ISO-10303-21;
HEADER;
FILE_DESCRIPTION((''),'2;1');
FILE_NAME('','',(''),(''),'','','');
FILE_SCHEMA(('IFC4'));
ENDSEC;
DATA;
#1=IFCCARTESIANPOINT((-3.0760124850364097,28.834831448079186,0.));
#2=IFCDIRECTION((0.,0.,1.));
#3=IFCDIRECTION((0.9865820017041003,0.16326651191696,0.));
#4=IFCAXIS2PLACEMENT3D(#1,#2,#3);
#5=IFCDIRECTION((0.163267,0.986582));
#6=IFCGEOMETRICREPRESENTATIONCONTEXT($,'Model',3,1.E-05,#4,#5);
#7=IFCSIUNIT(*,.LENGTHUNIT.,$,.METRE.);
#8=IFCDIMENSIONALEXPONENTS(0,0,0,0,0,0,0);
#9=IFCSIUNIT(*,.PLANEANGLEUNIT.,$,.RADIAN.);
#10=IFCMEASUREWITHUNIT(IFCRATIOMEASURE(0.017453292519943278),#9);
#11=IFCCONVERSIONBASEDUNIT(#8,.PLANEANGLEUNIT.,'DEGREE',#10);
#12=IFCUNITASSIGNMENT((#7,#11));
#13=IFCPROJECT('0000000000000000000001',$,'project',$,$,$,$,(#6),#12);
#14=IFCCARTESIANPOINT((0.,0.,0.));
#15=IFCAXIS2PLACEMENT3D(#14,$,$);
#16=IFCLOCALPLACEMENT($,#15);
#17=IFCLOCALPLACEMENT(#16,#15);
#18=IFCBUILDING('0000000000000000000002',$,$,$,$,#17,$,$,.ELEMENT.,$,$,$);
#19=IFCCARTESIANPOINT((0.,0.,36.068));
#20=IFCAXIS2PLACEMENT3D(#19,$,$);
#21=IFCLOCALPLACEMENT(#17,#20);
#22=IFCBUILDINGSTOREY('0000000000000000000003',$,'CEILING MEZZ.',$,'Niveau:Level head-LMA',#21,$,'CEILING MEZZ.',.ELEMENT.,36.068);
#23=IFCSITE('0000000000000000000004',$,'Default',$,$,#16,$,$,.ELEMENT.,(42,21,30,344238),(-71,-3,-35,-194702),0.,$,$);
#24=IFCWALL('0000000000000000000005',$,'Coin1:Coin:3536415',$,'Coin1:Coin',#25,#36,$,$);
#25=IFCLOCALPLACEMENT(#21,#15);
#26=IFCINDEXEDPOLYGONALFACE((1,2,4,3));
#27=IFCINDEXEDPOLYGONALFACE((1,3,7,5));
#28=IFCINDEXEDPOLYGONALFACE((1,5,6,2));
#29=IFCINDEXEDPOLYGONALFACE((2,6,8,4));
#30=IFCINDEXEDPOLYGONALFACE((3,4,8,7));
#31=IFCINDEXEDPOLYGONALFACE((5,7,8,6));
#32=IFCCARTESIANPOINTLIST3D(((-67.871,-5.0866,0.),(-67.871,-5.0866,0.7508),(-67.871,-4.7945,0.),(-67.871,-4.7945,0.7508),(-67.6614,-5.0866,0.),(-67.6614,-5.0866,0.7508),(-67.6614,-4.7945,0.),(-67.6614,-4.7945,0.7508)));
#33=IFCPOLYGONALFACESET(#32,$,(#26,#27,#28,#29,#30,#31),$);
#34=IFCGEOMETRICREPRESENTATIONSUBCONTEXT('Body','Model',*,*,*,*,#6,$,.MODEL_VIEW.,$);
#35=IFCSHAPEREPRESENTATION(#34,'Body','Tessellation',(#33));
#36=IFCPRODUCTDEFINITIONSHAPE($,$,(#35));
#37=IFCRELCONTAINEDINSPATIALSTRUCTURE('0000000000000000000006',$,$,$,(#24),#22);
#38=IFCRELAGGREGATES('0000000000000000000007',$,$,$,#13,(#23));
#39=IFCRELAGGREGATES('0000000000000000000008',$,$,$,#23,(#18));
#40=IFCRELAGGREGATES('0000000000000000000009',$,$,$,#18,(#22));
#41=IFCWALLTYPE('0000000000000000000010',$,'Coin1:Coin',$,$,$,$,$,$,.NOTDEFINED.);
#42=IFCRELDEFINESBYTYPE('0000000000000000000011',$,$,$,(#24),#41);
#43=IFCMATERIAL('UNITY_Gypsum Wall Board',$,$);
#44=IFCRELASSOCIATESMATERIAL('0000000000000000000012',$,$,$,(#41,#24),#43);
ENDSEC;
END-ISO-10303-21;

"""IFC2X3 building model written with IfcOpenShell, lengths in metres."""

from ifc_helpers import new_model, entity, si_unit, converted_unit, direction, frame, frame_2d, origin, place, context, subcontext, project, spatial, rectangle, extrude, material, type_object, element, save


model = new_model("IFC2X3")

# Units and contexts
model_context = context("Model", 3, precision=1e-05, world=frame((-3.0760124850364097, 28.834831448079186, 0.0), z_axis=(0.0, 0.0, 1.0), x_axis=(0.9865820017041003, 0.16326651191696, 0.0)), true_north=direction((0.163267, 0.986582)))
body_context = subcontext(model_context, "Body", "Model", "MODEL_VIEW")
ifc_project = project(units=[si_unit("LENGTHUNIT", "METRE"), converted_unit("PLANEANGLEUNIT", "DEGREE", entity("IfcRatioMeasure", 0.017453292519943278), si_unit("PLANEANGLEUNIT", "RADIAN"), dimensions=[0, 0, 0, 0, 0, 0, 0])], contexts=[model_context])

# Site, building, storey
site_placement = place(None, origin())
site = spatial("IfcSite", under=ifc_project, at=site_placement, Name="Default", CompositionType="ELEMENT", RefLatitude=(42, 21, 30, 344238), RefLongitude=(-71, -3, -35, -194702), RefElevation=0.0)
building_placement = place(site_placement, origin())
building = spatial("IfcBuilding", under=site, at=building_placement, CompositionType="ELEMENT")
storey_placement = place(building_placement, frame((0.0, 0.0, 36.068)))
storey = spatial("IfcBuildingStorey", under=building, at=storey_placement, Name="CEILING MEZZ.", ObjectType="Niveau:Level head-LMA", LongName="CEILING MEZZ.", CompositionType="ELEMENT", Elevation=36.068)

# Wall
ifc_material = material(Name="UNITY_Gypsum Wall Board")
wall_type = type_object("IfcWallType", Name="Coin1:Coin", PredefinedType="NOTDEFINED", material=ifc_material)
wall_placement = place(storey_placement, frame((-67.871, -5.0866, 0.0), z_axis=(0.0, 0.0, 1.0), x_axis=(0.0, 1.0, 0.0)))
element("IfcWall", 1, at=wall_placement, inside=storey, type_object=wall_type, material=ifc_material, Name="Coin1:Coin:3536415", ObjectType="Coin1:Coin", context=body_context, shape_type="SweptSolid", body=[
    extrude(rectangle(XDim=0.2096, YDim=0.2921, at=frame_2d((0.0, 0.0), x_axis=(1.0, 0.0))), frame((0.146, -0.1048, 0.0), z_axis=(0.0, 0.0, 1.0), x_axis=(0.0, 1.0, 0.0)), (0.0, 0.0, 1.0), 0.7508),
])

save(model, "model.ifc")
